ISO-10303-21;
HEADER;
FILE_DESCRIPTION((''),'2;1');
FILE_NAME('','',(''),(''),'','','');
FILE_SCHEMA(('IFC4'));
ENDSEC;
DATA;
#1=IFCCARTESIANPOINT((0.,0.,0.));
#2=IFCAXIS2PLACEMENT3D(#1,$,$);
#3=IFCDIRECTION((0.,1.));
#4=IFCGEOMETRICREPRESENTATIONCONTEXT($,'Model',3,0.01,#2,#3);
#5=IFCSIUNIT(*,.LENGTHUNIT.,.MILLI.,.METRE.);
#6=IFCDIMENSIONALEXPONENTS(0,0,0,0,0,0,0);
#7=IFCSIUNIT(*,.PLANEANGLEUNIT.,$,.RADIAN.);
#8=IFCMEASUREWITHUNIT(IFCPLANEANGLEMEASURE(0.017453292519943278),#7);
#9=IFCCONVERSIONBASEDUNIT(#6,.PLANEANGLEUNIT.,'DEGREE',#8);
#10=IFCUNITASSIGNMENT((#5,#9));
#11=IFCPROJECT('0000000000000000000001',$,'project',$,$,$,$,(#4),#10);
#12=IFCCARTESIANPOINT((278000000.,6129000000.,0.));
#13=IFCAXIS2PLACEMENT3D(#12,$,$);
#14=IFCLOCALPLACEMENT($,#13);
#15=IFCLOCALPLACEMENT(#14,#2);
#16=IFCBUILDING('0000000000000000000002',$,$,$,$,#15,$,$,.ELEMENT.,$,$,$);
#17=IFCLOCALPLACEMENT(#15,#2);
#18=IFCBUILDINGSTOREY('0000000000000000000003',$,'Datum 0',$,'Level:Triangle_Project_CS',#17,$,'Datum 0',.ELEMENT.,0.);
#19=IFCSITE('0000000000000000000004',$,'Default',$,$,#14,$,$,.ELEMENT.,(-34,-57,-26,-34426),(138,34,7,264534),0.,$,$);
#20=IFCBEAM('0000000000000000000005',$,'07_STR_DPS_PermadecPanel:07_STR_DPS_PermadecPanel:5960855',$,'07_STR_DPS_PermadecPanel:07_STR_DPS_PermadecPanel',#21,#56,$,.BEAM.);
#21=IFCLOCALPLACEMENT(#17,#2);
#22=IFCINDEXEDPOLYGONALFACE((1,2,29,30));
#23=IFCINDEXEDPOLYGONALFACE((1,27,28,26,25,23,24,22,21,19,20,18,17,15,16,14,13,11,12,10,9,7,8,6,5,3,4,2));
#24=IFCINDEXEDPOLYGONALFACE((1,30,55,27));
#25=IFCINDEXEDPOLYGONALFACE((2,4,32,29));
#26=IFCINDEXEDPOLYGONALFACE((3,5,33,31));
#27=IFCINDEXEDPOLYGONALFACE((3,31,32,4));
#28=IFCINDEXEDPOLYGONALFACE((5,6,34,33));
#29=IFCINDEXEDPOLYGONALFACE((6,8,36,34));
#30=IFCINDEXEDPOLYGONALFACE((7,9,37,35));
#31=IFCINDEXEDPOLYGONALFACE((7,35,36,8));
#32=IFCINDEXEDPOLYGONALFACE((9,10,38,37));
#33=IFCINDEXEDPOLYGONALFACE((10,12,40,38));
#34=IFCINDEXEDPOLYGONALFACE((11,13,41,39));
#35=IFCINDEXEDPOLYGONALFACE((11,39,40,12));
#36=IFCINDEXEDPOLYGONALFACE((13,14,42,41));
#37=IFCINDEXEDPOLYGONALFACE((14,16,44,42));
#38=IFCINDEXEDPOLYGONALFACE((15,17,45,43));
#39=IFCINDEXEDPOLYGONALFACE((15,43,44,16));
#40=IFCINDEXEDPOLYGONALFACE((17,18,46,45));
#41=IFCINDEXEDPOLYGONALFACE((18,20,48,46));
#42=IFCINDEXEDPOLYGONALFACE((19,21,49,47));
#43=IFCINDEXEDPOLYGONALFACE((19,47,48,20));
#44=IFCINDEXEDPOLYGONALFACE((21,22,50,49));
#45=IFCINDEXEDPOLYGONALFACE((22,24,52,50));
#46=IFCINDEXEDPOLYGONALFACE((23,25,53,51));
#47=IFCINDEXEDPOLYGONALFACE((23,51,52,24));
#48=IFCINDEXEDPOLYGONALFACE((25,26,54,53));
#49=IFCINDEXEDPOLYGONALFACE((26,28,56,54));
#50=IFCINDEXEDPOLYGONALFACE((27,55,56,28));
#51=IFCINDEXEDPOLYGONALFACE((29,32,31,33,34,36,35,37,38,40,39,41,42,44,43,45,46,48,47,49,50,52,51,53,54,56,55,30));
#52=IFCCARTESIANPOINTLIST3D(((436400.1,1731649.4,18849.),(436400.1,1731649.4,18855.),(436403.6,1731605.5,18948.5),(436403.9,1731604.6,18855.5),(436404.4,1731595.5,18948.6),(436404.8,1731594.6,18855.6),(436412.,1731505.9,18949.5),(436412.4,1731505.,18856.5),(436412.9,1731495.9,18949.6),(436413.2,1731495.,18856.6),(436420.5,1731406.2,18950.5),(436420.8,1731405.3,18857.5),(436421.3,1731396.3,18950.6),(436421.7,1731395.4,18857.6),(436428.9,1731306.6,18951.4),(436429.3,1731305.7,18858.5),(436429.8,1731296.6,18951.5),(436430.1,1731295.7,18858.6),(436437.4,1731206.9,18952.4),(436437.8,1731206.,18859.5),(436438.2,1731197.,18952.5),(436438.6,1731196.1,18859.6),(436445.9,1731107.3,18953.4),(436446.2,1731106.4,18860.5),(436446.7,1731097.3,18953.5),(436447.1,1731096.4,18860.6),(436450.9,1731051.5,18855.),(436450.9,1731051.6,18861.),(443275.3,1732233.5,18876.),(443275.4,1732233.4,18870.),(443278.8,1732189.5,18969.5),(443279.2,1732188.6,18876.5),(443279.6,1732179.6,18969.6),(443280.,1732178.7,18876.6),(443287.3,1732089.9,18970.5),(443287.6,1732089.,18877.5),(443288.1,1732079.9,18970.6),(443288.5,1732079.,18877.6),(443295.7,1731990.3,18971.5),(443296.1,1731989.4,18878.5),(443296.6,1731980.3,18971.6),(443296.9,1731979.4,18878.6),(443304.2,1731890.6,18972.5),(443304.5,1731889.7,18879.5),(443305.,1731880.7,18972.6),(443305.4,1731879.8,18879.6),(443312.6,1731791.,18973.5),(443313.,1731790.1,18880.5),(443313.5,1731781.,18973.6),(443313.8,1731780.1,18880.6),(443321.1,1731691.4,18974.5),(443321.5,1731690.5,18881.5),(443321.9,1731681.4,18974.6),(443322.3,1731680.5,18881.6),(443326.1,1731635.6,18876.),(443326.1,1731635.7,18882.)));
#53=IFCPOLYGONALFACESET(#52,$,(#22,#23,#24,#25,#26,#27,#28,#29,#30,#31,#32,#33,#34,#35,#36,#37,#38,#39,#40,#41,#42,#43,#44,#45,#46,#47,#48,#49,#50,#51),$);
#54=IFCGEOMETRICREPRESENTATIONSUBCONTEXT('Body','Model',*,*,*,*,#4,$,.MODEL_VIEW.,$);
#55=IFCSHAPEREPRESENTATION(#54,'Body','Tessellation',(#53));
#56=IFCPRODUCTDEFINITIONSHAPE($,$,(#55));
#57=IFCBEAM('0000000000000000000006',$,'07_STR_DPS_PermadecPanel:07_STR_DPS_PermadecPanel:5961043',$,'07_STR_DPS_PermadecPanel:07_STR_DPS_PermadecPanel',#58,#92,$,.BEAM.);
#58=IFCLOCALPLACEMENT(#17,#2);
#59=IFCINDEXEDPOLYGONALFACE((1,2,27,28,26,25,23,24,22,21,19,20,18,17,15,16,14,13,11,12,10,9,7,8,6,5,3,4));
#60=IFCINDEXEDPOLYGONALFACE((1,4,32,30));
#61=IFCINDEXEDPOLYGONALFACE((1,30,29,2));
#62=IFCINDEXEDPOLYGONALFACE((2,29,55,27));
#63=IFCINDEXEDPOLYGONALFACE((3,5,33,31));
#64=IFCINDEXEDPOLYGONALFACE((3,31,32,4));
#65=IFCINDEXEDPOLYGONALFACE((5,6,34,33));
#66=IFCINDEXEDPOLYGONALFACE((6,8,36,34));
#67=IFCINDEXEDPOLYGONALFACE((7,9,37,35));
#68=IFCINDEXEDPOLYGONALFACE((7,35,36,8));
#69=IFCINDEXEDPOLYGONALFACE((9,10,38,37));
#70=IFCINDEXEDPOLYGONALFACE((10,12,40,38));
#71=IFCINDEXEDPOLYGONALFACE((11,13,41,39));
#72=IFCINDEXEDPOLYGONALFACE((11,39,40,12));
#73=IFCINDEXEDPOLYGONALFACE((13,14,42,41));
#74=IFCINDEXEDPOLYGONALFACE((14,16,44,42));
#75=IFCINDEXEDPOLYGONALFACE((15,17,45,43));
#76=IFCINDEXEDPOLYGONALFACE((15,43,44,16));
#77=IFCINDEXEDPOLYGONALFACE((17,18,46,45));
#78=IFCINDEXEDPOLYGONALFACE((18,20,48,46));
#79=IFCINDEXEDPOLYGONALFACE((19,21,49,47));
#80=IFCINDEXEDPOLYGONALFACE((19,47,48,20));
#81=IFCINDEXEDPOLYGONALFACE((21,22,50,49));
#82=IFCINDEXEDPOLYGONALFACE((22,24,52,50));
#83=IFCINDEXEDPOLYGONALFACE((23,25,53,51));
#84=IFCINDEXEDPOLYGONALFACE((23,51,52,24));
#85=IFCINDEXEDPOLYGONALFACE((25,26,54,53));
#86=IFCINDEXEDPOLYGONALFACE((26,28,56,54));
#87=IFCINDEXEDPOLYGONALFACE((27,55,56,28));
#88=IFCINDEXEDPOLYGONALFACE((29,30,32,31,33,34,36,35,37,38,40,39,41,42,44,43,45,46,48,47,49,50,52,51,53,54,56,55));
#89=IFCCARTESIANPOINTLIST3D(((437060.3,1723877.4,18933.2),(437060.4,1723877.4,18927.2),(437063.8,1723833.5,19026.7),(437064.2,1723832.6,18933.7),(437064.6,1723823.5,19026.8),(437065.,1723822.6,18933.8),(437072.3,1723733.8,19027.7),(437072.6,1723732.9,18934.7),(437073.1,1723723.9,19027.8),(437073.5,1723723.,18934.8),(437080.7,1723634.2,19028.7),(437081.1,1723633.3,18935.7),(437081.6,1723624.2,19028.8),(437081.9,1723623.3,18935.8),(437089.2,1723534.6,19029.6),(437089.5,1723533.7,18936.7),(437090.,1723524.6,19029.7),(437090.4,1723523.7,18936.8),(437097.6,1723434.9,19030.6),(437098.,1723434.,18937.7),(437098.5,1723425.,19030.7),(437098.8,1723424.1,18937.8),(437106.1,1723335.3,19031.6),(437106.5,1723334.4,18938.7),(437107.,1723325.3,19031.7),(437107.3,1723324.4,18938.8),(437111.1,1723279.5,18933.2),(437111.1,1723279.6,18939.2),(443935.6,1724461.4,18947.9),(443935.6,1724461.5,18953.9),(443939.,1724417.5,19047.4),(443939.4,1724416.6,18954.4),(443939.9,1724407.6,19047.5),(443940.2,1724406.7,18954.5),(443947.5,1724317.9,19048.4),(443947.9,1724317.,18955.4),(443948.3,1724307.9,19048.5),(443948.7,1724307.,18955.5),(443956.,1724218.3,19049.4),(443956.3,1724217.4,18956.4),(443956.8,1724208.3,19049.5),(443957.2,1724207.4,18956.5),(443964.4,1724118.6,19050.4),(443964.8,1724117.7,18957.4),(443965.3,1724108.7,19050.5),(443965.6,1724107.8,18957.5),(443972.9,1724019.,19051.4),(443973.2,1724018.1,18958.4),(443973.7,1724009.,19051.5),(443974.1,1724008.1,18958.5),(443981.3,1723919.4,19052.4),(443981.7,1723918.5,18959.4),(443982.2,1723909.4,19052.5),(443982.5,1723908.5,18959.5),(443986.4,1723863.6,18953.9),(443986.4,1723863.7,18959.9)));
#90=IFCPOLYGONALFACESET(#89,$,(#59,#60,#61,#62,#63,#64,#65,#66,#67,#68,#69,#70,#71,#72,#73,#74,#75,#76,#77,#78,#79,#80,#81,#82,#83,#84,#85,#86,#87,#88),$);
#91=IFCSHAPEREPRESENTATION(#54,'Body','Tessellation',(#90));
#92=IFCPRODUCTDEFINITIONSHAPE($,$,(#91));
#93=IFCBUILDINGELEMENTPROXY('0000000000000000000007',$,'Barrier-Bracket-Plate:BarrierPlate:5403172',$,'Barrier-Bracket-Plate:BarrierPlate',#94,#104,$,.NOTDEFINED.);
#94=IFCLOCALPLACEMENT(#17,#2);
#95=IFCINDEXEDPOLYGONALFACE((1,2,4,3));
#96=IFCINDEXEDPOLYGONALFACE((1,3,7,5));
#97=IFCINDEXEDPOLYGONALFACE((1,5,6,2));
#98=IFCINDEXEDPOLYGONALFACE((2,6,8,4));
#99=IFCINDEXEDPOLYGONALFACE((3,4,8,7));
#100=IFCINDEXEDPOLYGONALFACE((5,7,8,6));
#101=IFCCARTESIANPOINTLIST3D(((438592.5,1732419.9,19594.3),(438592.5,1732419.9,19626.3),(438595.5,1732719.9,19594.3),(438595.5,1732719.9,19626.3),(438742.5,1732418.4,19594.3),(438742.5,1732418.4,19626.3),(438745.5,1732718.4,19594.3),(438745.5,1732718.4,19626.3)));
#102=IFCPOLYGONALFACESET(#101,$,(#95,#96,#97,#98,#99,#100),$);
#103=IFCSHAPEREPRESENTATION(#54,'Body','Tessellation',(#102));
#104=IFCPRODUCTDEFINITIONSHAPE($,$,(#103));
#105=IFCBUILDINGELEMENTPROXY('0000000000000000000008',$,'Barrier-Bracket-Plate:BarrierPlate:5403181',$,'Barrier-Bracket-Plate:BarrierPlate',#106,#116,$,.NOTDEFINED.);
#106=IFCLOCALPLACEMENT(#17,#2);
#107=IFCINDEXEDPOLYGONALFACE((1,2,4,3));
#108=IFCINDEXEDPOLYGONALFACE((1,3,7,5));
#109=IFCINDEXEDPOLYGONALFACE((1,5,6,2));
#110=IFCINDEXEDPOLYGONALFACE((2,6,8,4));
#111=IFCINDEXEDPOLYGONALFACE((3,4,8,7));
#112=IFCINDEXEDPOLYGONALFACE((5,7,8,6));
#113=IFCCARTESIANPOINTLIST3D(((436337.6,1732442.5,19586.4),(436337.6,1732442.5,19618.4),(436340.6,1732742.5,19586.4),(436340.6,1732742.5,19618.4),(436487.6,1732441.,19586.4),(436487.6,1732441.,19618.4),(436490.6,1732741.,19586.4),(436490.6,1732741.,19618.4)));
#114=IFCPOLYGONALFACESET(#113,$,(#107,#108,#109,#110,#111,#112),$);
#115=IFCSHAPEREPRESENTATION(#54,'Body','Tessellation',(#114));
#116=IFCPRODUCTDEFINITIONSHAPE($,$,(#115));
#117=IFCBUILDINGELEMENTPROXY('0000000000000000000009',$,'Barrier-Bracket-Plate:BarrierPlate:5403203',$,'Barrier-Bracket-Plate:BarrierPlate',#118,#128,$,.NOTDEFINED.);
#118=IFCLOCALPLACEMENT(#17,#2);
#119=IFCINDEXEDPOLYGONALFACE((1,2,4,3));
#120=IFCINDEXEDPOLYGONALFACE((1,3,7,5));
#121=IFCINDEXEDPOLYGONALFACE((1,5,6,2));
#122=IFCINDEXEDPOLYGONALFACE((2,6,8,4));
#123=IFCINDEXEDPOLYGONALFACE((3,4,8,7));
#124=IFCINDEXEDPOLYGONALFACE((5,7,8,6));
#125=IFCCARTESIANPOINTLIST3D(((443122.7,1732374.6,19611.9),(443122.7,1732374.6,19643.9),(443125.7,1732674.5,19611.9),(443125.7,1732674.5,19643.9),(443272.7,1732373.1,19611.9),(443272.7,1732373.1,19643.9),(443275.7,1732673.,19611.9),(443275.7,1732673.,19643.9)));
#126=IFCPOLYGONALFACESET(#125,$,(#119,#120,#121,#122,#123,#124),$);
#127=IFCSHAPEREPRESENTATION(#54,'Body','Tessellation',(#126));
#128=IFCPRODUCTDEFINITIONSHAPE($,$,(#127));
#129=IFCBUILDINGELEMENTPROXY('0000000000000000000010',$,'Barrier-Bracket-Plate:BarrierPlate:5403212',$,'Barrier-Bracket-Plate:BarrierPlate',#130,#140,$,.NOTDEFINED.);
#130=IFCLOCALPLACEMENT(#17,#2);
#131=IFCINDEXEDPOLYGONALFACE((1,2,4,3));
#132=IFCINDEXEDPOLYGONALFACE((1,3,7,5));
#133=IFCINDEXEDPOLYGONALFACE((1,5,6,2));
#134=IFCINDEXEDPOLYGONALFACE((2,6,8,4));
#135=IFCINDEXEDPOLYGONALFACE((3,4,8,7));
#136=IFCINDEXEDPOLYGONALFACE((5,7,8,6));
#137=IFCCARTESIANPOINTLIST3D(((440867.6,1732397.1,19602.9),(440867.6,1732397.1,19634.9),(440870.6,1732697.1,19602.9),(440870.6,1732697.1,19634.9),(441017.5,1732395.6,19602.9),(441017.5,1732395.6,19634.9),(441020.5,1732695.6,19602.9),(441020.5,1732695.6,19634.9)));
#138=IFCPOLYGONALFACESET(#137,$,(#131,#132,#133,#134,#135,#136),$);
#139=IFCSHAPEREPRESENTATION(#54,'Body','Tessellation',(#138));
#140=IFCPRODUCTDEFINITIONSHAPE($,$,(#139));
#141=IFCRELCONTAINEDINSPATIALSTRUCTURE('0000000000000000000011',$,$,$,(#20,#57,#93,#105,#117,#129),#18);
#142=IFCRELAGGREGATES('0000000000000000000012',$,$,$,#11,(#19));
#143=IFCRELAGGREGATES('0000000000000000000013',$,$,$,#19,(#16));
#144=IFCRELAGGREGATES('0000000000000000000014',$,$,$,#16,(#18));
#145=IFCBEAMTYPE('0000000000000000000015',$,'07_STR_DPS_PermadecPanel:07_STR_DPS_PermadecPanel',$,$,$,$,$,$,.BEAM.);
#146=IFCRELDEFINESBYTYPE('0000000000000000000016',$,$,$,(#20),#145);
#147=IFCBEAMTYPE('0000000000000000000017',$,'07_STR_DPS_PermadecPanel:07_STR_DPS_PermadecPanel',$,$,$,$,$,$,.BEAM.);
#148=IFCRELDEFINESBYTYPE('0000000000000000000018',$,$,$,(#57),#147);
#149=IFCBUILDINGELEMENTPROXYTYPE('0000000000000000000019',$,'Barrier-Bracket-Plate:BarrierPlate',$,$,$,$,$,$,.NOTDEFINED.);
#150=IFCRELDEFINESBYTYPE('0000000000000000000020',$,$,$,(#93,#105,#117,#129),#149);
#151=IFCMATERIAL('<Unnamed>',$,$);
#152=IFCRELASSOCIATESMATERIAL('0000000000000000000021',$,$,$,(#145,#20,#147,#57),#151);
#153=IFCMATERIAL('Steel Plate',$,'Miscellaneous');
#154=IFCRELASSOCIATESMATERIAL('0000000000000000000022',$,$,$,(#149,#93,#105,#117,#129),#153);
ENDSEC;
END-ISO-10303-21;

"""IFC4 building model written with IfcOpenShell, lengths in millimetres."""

from ifc_helpers import new_model, entity, si_unit, converted_unit, direction, frame, origin, place, context, subcontext, project, spatial, indexed_curve, outline, extrude, source, transform, mapped, material, type_object, type_shapes, element, save


model = new_model("IFC4")

# Units and contexts
model_context = context("Model", 3, precision=0.01, world=origin(), true_north=direction((0.0, 1.0)))
body_context = subcontext(model_context, "Body", "Model", "MODEL_VIEW")
ifc_project = project(units=[si_unit("LENGTHUNIT", "METRE", prefix="MILLI"), converted_unit("PLANEANGLEUNIT", "DEGREE", entity("IfcPlaneAngleMeasure", 0.017453292519943278), si_unit("PLANEANGLEUNIT", "RADIAN"), dimensions=[0, 0, 0, 0, 0, 0, 0])], contexts=[model_context])

# Site, building, storey
site_placement = place(None, frame((278000000.0, 6129000000.0, 0.0)))
site = spatial("IfcSite", under=ifc_project, at=site_placement, Name="Default", CompositionType="ELEMENT", RefLatitude=(-34, -57, -26, -34426), RefLongitude=(138, 34, 7, 264534), RefElevation=0.0)
building_placement = place(site_placement, origin())
building = spatial("IfcBuilding", under=site, at=building_placement, CompositionType="ELEMENT")
storey_placement = place(building_placement, frame((0.0, 0.0, 0.0)))
storey = spatial("IfcBuildingStorey", under=building, at=storey_placement, Name="Datum 0", ObjectType="Level:Triangle_Project_CS", LongName="Datum 0", CompositionType="ELEMENT", Elevation=0.0)

# Beams
ifc_material_1 = material(Name="<Unnamed>")
beam_type_1 = type_object("IfcBeamType", Name="07_STR_DPS_PermadecPanel:07_STR_DPS_PermadecPanel", PredefinedType="BEAM", material=ifc_material_1)
shared_shape_1 = source(origin(), body_context, "Body", "SweptSolid", [
    extrude(outline(indexed_curve([(-300.0, -45.4), (300.0, -45.4), (300.0, -39.4), (255.0, -39.4), (255.0, 53.6), (245.0, 53.6), (245.0, -39.4), (155.0, -39.4), (155.0, 53.6), (145.0, 53.6), (145.0, -39.4), (55.0, -39.4), (55.0, 53.6), (45.0, 53.6), (45.0, -39.4), (-45.0, -39.4), (-45.0, 53.6), (-55.0, 53.6), (-55.0, -39.4), (-145.0, -39.4), (-145.0, 53.6), (-155.0, 53.6), (-155.0, -39.4), (-245.0, -39.4), (-245.0, 53.6), (-255.0, 53.6), (-255.0, -39.4), (-300.0, -39.4), (-300.0, -45.4)], self_intersect=False)), frame((-3450.0, 0.0, 45.4), z_axis=(1.0, 0.0, 0.0), x_axis=(0.0, 1.0, 0.0)), (0.0, 0.0, 1.0), 6900.0),
])
type_shapes(beam_type_1, [shared_shape_1])
beam_1_placement = place(storey_placement, frame((439863.1, 1731642.5, 18862.5), z_axis=(-0.00388, 0.009693, 0.999945), x_axis=(-0.996406, -0.084646, -0.003046)))
element("IfcBeam", 1, at=beam_1_placement, inside=storey, type_object=beam_type_1, material=ifc_material_1, Name="07_STR_DPS_PermadecPanel:07_STR_DPS_PermadecPanel:5960855", ObjectType="07_STR_DPS_PermadecPanel:07_STR_DPS_PermadecPanel", PredefinedType="BEAM", context=body_context, shape_type="MappedRepresentation", body=[
    mapped(shared_shape_1, transform((0.0, 0.0, 0.0), scale=1.0)),
])
beam_type_2 = type_object("IfcBeamType", Name="07_STR_DPS_PermadecPanel:07_STR_DPS_PermadecPanel", PredefinedType="BEAM", material=ifc_material_1)
shared_shape_2 = source(origin(), body_context, "Body", "SweptSolid", [
    extrude(outline(indexed_curve([(-300.0, -45.4), (300.0, -45.4), (300.0, -39.4), (255.0, -39.4), (255.0, 53.6), (245.0, 53.6), (245.0, -39.4), (155.0, -39.4), (155.0, 53.6), (145.0, 53.6), (145.0, -39.4), (55.0, -39.4), (55.0, 53.6), (45.0, 53.6), (45.0, -39.4), (-45.0, -39.4), (-45.0, 53.6), (-55.0, 53.6), (-55.0, -39.4), (-145.0, -39.4), (-145.0, 53.6), (-155.0, 53.6), (-155.0, -39.4), (-245.0, -39.4), (-245.0, 53.6), (-255.0, 53.6), (-255.0, -39.4), (-300.0, -39.4), (-300.0, -45.4)], self_intersect=False)), frame((-3450.0, 0.0, 45.4), z_axis=(1.0, 0.0, 0.0), x_axis=(0.0, 1.0, 0.0)), (0.0, 0.0, 1.0), 6900.0),
])
type_shapes(beam_type_2, [shared_shape_2])
for number, where, z_axis, x_axis, name in (
    (2, (440523.4, 1723870.5, 18940.6), (-0.003835, 0.009697, 0.999946), (-0.996407, -0.084646, -0.003001), "07_STR_DPS_PermadecPanel:07_STR_DPS_PermadecPanel:5961043"),
):
    element("IfcBeam", number, at=place(storey_placement, frame(where, z_axis=z_axis, x_axis=x_axis)), inside=storey, type_object=beam_type_2, material=ifc_material_1, Name=name, ObjectType="07_STR_DPS_PermadecPanel:07_STR_DPS_PermadecPanel", PredefinedType="BEAM", context=body_context, shape_type="MappedRepresentation", body=[
        mapped(shared_shape_2, transform((0.0, 0.0, 0.0), scale=1.0)),
    ])

# Building element proxies
ifc_material_2 = material(Name="Steel Plate", Category="Miscellaneous")
building_element_proxy_type = type_object("IfcBuildingElementProxyType", Name="Barrier-Bracket-Plate:BarrierPlate", PredefinedType="NOTDEFINED", material=ifc_material_2)
shared_shape_3 = source(origin(), body_context, "Body", "SweptSolid", [
    extrude(outline(indexed_curve([(-150.0, -75.0), (150.0, -75.0), (150.0, 75.0), (-150.0, 75.0), (-150.0, -75.0)], self_intersect=False)), frame((-150.0, 0.0, 0.0), z_axis=(0.0, 0.0, 1.0), x_axis=(-1.0, 0.0, 0.0)), (0.0, 0.0, 1.0), 32.0),
])
type_shapes(building_element_proxy_type, [shared_shape_3])
for number, where, z_axis, x_axis, name in (
    (3, (438667.5, 1732419.2, 19594.3), (0.0, 0.0, 1.0), (-0.010008, -0.99995, 0.0), "Barrier-Bracket-Plate:BarrierPlate:5403172"),
    (4, (436412.6, 1732441.7, 19586.4), (0.0, 0.0, 1.0), (-0.010008, -0.99995, 0.0), "Barrier-Bracket-Plate:BarrierPlate:5403181"),
    (5, (443197.7, 1732373.8, 19611.9), (0.0, 0.0, 1.0), (-0.010008, -0.99995, 0.0), "Barrier-Bracket-Plate:BarrierPlate:5403203"),
    (6, (440942.5, 1732396.4, 19602.9), (0.0, 0.0, 1.0), (-0.010008, -0.99995, 0.0), "Barrier-Bracket-Plate:BarrierPlate:5403212"),
):
    element("IfcBuildingElementProxy", number, at=place(storey_placement, frame(where, z_axis=z_axis, x_axis=x_axis)), inside=storey, type_object=building_element_proxy_type, material=ifc_material_2, Name=name, ObjectType="Barrier-Bracket-Plate:BarrierPlate", PredefinedType="NOTDEFINED", context=body_context, shape_type="MappedRepresentation", body=[
        mapped(shared_shape_3, transform((0.0, 0.0, 0.0), scale=1.0)),
    ])

save(model, "model.ifc")
